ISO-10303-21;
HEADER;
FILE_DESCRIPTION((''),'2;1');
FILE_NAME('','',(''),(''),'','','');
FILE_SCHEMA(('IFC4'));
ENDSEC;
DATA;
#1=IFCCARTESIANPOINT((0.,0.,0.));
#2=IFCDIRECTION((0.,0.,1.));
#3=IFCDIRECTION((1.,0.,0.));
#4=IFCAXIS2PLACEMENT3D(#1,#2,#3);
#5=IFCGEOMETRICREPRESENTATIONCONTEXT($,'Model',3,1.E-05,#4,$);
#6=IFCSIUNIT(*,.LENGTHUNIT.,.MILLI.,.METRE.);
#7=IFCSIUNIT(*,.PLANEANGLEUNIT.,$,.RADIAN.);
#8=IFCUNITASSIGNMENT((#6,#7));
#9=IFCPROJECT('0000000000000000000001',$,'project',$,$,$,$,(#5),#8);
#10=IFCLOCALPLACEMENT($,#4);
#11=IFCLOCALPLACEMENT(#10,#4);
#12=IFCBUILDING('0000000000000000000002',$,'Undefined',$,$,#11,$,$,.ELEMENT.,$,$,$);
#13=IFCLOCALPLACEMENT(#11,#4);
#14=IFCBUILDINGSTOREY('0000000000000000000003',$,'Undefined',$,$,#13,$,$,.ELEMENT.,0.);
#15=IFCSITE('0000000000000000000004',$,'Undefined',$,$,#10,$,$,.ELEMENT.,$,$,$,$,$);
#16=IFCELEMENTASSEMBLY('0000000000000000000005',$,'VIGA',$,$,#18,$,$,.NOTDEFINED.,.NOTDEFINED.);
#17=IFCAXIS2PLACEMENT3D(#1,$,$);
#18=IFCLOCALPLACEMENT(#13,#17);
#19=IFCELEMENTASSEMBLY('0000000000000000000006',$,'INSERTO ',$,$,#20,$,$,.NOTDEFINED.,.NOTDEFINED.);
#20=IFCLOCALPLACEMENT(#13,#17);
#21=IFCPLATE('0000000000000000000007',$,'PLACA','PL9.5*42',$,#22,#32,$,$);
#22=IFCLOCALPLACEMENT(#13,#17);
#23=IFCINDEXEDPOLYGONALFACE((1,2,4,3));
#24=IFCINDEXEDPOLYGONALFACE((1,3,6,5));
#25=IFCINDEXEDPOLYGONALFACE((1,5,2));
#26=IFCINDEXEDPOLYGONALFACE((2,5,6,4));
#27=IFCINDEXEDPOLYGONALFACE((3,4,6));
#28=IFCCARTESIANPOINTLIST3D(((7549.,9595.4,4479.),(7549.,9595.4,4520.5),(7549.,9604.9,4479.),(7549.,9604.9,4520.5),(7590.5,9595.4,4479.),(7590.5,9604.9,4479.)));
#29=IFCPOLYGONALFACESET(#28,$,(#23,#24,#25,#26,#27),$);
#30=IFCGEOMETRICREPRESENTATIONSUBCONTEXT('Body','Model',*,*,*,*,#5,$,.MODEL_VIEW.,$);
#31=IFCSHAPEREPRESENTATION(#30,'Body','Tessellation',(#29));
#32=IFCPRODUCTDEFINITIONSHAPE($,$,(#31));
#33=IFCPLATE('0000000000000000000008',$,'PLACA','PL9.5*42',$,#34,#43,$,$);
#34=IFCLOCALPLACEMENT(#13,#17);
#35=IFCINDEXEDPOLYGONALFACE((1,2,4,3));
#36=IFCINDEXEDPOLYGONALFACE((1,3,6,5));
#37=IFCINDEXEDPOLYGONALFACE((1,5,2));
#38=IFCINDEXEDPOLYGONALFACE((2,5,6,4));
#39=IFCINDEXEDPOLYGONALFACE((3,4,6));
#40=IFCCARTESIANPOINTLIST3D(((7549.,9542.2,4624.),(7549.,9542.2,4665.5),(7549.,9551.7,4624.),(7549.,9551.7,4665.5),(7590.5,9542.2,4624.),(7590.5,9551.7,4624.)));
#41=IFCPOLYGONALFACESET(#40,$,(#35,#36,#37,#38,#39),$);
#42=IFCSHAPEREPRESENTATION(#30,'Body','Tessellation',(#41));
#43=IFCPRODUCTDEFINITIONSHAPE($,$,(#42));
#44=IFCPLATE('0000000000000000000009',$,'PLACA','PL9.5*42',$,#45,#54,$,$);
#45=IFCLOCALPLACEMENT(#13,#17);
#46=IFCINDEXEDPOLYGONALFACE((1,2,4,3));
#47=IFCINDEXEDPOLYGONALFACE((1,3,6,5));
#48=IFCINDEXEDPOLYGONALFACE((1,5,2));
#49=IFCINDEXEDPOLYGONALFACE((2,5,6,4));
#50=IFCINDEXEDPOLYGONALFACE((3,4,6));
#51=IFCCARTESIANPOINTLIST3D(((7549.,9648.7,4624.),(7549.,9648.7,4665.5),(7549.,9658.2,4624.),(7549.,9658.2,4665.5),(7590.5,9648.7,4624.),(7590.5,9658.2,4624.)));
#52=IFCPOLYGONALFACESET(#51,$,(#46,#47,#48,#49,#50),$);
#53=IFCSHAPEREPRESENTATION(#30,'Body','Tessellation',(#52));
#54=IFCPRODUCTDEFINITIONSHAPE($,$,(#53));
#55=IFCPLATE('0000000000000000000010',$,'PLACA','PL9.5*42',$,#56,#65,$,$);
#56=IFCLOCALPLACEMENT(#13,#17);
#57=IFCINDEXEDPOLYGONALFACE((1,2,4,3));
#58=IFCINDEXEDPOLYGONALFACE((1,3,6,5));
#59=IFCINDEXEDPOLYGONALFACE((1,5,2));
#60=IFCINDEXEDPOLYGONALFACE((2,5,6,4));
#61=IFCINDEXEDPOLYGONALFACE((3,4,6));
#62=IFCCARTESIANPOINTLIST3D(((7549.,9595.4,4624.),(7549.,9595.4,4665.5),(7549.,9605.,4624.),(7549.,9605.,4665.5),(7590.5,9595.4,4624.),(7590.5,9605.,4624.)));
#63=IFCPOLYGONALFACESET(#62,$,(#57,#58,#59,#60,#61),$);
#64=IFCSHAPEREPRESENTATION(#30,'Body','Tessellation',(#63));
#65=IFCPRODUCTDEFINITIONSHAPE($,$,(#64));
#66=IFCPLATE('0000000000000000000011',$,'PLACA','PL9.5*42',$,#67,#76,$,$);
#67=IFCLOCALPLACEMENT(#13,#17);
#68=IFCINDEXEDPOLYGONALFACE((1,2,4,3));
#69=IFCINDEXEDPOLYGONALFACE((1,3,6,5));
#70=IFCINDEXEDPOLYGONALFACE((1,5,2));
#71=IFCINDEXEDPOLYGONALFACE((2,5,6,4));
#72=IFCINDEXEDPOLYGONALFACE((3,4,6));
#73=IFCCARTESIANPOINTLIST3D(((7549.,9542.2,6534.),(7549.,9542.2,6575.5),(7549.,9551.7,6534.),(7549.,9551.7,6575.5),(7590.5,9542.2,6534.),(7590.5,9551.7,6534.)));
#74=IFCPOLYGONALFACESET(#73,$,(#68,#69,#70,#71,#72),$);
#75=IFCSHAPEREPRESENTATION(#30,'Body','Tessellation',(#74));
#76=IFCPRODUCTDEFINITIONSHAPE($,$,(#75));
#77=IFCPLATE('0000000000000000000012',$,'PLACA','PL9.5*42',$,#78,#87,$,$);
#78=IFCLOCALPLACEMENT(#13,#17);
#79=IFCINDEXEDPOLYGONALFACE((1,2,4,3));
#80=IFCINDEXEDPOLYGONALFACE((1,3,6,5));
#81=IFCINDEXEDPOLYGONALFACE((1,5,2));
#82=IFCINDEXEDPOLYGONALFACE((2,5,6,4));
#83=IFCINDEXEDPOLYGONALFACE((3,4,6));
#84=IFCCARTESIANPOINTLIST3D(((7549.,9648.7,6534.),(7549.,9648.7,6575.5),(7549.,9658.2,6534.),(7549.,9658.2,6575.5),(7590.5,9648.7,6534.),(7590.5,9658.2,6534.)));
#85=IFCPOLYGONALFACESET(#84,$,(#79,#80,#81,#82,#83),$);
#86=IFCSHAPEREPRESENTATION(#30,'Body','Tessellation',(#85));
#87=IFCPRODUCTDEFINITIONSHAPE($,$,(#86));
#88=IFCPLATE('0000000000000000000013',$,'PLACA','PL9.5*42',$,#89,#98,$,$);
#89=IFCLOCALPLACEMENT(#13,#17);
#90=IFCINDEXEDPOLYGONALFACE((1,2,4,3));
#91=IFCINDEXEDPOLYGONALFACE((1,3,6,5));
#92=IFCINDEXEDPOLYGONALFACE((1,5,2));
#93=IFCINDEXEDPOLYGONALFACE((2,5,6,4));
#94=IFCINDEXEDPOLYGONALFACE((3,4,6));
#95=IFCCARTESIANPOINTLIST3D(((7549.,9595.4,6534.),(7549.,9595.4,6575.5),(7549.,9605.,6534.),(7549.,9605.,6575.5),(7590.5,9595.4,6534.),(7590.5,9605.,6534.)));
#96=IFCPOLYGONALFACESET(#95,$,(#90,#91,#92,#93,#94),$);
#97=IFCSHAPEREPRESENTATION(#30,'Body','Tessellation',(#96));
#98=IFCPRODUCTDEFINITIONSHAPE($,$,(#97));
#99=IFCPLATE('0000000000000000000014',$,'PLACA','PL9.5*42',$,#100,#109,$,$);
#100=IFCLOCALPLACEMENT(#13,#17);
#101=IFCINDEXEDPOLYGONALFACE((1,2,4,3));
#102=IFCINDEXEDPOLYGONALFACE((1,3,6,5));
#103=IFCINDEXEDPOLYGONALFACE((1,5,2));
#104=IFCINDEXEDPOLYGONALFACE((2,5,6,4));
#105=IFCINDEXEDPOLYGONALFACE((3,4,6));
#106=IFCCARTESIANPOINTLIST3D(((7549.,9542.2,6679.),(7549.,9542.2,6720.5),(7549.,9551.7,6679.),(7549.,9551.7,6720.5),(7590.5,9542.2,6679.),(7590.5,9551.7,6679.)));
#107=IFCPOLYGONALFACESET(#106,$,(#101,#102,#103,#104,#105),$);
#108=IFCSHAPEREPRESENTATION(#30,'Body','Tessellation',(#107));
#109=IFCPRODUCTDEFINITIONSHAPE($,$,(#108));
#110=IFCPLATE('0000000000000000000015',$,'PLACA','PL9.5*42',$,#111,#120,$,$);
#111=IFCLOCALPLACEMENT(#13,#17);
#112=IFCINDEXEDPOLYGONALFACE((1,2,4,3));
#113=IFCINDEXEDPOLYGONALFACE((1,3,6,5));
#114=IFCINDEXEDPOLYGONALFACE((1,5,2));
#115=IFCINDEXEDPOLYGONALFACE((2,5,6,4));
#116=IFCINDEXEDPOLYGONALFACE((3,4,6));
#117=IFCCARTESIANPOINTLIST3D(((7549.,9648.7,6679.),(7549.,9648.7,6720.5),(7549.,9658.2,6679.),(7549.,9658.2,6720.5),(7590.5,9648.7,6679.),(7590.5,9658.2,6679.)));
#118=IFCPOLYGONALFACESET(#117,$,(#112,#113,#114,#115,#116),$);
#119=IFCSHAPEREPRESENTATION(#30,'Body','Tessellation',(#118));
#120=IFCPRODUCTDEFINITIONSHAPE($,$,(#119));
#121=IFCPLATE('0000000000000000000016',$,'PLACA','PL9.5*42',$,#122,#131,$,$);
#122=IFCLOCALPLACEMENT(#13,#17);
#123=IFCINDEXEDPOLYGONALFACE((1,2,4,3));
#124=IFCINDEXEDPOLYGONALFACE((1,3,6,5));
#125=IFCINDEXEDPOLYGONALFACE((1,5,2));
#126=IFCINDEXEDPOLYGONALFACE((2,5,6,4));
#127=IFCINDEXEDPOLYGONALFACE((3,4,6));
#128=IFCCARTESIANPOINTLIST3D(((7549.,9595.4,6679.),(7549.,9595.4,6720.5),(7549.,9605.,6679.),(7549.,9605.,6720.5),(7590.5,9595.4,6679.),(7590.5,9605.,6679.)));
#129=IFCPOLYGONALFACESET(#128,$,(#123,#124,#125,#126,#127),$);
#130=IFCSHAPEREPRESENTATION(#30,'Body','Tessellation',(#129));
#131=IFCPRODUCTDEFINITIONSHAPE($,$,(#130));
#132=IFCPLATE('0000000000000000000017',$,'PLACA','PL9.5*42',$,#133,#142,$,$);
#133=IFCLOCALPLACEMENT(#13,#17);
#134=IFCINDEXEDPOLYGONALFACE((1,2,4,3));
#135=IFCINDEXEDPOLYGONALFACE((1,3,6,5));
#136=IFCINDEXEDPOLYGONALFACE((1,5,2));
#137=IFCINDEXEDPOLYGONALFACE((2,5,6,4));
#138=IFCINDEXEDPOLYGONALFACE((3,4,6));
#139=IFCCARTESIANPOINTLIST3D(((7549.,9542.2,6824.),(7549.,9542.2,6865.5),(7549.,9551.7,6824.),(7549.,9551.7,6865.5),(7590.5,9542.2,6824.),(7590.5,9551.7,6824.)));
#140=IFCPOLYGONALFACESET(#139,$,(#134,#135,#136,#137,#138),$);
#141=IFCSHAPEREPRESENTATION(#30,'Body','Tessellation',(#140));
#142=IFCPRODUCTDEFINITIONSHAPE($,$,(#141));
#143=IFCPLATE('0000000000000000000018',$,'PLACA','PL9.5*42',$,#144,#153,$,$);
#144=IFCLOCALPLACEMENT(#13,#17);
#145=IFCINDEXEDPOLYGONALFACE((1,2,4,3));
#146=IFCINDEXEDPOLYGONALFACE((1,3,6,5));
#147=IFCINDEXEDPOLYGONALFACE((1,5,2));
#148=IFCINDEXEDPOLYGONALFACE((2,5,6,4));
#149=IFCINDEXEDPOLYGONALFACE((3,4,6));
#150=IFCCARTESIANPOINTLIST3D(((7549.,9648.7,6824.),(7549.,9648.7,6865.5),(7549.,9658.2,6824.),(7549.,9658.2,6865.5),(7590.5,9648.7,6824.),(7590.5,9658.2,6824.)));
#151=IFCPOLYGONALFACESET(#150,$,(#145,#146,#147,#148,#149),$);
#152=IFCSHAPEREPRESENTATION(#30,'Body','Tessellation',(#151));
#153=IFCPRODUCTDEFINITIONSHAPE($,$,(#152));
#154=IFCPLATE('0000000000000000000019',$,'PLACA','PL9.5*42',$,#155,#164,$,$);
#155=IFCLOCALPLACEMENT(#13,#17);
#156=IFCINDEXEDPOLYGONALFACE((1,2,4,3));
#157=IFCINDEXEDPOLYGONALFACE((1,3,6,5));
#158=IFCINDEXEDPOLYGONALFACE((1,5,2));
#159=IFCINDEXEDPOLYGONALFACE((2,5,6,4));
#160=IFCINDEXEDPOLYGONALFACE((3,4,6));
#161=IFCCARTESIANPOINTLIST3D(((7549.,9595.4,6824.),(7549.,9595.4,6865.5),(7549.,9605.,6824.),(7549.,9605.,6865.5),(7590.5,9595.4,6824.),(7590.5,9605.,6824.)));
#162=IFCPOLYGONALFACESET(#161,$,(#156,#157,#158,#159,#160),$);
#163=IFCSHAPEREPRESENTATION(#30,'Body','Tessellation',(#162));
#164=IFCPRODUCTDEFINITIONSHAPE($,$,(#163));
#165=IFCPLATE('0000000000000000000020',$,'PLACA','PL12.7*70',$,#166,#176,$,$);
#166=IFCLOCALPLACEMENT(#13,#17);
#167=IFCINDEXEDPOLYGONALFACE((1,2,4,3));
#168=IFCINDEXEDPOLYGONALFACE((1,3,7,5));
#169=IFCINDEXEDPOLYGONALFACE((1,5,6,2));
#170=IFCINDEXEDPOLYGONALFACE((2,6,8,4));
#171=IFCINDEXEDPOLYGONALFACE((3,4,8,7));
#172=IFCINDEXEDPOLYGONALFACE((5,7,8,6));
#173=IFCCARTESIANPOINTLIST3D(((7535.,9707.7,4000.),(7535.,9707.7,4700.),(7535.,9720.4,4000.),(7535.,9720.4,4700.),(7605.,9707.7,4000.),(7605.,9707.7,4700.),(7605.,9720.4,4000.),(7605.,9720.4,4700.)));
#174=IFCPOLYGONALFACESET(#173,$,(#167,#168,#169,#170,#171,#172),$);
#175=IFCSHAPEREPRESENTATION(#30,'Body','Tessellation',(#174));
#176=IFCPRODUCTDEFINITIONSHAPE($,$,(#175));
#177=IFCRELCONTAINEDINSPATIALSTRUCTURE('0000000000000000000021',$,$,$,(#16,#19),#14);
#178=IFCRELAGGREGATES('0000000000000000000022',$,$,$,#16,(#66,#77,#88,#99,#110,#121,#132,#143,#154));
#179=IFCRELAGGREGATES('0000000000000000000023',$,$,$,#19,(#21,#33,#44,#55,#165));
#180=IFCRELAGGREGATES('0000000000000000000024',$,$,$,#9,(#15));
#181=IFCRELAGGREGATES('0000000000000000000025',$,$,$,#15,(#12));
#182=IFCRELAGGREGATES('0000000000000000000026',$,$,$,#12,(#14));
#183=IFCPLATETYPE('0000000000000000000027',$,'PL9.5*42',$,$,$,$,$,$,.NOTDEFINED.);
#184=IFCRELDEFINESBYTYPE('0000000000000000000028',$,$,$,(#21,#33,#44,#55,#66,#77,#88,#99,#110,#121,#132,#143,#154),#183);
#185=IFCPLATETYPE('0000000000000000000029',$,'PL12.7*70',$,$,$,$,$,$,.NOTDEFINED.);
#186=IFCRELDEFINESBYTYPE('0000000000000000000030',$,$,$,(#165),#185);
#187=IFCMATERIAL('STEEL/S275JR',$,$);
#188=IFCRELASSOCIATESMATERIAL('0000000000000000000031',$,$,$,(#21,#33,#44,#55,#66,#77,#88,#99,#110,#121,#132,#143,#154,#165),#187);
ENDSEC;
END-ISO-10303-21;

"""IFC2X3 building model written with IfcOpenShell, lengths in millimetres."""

from ifc_helpers import new_model, si_unit, frame, origin_with_axes, place, context, subcontext, project, spatial, polyline, outline, extrude, material, type_object, element, aggregate, save


model = new_model("IFC2X3")

# Units and contexts
model_context = context("Model", 3, precision=1e-05, world=origin_with_axes())
body_context = subcontext(model_context, "Body", "Model", "MODEL_VIEW")
ifc_project = project(units=[si_unit("LENGTHUNIT", "METRE", prefix="MILLI"), si_unit("PLANEANGLEUNIT", "RADIAN")], contexts=[model_context])

# Site, building, storey
site_placement = place(None, origin_with_axes())
site = spatial("IfcSite", under=ifc_project, at=site_placement, Name="Undefined", CompositionType="ELEMENT")
building_placement = place(site_placement, origin_with_axes())
building = spatial("IfcBuilding", under=site, at=building_placement, Name="Undefined", CompositionType="ELEMENT")
storey_placement = place(building_placement, origin_with_axes())
storey = spatial("IfcBuildingStorey", under=building, at=storey_placement, Name="Undefined", CompositionType="ELEMENT", Elevation=0.0)

# Element assembly
assembly_1_placement = place(storey_placement, origin_with_axes())
assembly_1 = element("IfcElementAssembly", 1, at=assembly_1_placement, inside=storey, Name="VIGA", AssemblyPlace="NOTDEFINED", PredefinedType="NOTDEFINED")
ifc_material = material(Name="STEEL/S275JR")

# Element assembly, plates
assembly_2_placement = place(storey_placement, origin_with_axes())
assembly_2 = element("IfcElementAssembly", 2, at=assembly_2_placement, inside=storey, Name="INSERTO ", AssemblyPlace="NOTDEFINED", PredefinedType="NOTDEFINED")
plate_type_1 = type_object("IfcPlateType", Name="PL9.5*42", PredefinedType="NOTDEFINED")
plate_1_placement = place(assembly_2_placement, frame((7549.0, 9600.2, 4479.0), z_axis=(0.0, 1.0, 0.0), x_axis=(0.0, 0.0, 1.0)))
plate_1 = element("IfcPlate", 3, at=plate_1_placement, type_object=plate_type_1, material=ifc_material, Name="PLACA", Description="PL9.5*42", context=body_context, shape_type="SweptSolid", body=[
    extrude(outline(polyline([(0.0, 0.0), (41.5, 0.0), (0.0, 41.5), (0.0, 0.0)])), frame((0.0, 0.0, -4.7), z_axis=(0.0, 0.0, 1.0), x_axis=(1.0, 0.0, 0.0)), (0.0, 0.0, 1.0), 9.5),
])
plate_2_placement = place(assembly_2_placement, frame((7549.0, 9547.0, 4624.0), z_axis=(0.0, 1.0, 0.0), x_axis=(0.0, 0.0, 1.0)))
plate_2 = element("IfcPlate", 4, at=plate_2_placement, type_object=plate_type_1, material=ifc_material, Name="PLACA", Description="PL9.5*42", context=body_context, shape_type="SweptSolid", body=[
    extrude(outline(polyline([(0.0, 0.0), (41.5, 0.0), (0.0, 41.5), (0.0, 0.0)])), frame((0.0, 0.0, -4.7), z_axis=(0.0, 0.0, 1.0), x_axis=(1.0, 0.0, 0.0)), (0.0, 0.0, 1.0), 9.5),
])
plate_3_placement = place(assembly_2_placement, frame((7549.0, 9653.5, 4624.0), z_axis=(0.0, 1.0, 0.0), x_axis=(0.0, 0.0, 1.0)))
plate_3 = element("IfcPlate", 5, at=plate_3_placement, type_object=plate_type_1, material=ifc_material, Name="PLACA", Description="PL9.5*42", context=body_context, shape_type="SweptSolid", body=[
    extrude(outline(polyline([(0.0, 0.0), (41.5, 0.0), (0.0, 41.5), (0.0, 0.0)])), frame((0.0, 0.0, -4.7), z_axis=(0.0, 0.0, 1.0), x_axis=(1.0, 0.0, 0.0)), (0.0, 0.0, 1.0), 9.5),
])
plate_4_placement = place(assembly_2_placement, frame((7549.0, 9600.2, 4624.0), z_axis=(0.0, 1.0, 0.0), x_axis=(0.0, 0.0, 1.0)))
plate_4 = element("IfcPlate", 6, at=plate_4_placement, type_object=plate_type_1, material=ifc_material, Name="PLACA", Description="PL9.5*42", context=body_context, shape_type="SweptSolid", body=[
    extrude(outline(polyline([(0.0, 0.0), (41.5, 0.0), (0.0, 41.5), (0.0, 0.0)])), frame((0.0, 0.0, -4.7), z_axis=(0.0, 0.0, 1.0), x_axis=(1.0, 0.0, 0.0)), (0.0, 0.0, 1.0), 9.5),
])

# Plates
plate_5_placement = place(assembly_1_placement, frame((7549.0, 9547.0, 6534.0), z_axis=(0.0, 1.0, 0.0), x_axis=(0.0, 0.0, 1.0)))
plate_5 = element("IfcPlate", 7, at=plate_5_placement, type_object=plate_type_1, material=ifc_material, Name="PLACA", Description="PL9.5*42", context=body_context, shape_type="SweptSolid", body=[
    extrude(outline(polyline([(0.0, 0.0), (41.5, 0.0), (0.0, 41.5), (0.0, 0.0)])), frame((0.0, 0.0, -4.7), z_axis=(0.0, 0.0, 1.0), x_axis=(1.0, 0.0, 0.0)), (0.0, 0.0, 1.0), 9.5),
])
plate_6_placement = place(assembly_1_placement, frame((7549.0, 9653.5, 6534.0), z_axis=(0.0, 1.0, 0.0), x_axis=(0.0, 0.0, 1.0)))
plate_6 = element("IfcPlate", 8, at=plate_6_placement, type_object=plate_type_1, material=ifc_material, Name="PLACA", Description="PL9.5*42", context=body_context, shape_type="SweptSolid", body=[
    extrude(outline(polyline([(0.0, 0.0), (41.5, 0.0), (0.0, 41.5), (0.0, 0.0)])), frame((0.0, 0.0, -4.7), z_axis=(0.0, 0.0, 1.0), x_axis=(1.0, 0.0, 0.0)), (0.0, 0.0, 1.0), 9.5),
])
plate_7_placement = place(assembly_1_placement, frame((7549.0, 9600.2, 6534.0), z_axis=(0.0, 1.0, 0.0), x_axis=(0.0, 0.0, 1.0)))
plate_7 = element("IfcPlate", 9, at=plate_7_placement, type_object=plate_type_1, material=ifc_material, Name="PLACA", Description="PL9.5*42", context=body_context, shape_type="SweptSolid", body=[
    extrude(outline(polyline([(0.0, 0.0), (41.5, 0.0), (0.0, 41.5), (0.0, 0.0)])), frame((0.0, 0.0, -4.7), z_axis=(0.0, 0.0, 1.0), x_axis=(1.0, 0.0, 0.0)), (0.0, 0.0, 1.0), 9.5),
])
plate_8_placement = place(assembly_1_placement, frame((7549.0, 9547.0, 6679.0), z_axis=(0.0, 1.0, 0.0), x_axis=(0.0, 0.0, 1.0)))
plate_8 = element("IfcPlate", 10, at=plate_8_placement, type_object=plate_type_1, material=ifc_material, Name="PLACA", Description="PL9.5*42", context=body_context, shape_type="SweptSolid", body=[
    extrude(outline(polyline([(0.0, 0.0), (41.5, 0.0), (0.0, 41.5), (0.0, 0.0)])), frame((0.0, 0.0, -4.7), z_axis=(0.0, 0.0, 1.0), x_axis=(1.0, 0.0, 0.0)), (0.0, 0.0, 1.0), 9.5),
])
plate_9_placement = place(assembly_1_placement, frame((7549.0, 9653.5, 6679.0), z_axis=(0.0, 1.0, 0.0), x_axis=(0.0, 0.0, 1.0)))
plate_9 = element("IfcPlate", 11, at=plate_9_placement, type_object=plate_type_1, material=ifc_material, Name="PLACA", Description="PL9.5*42", context=body_context, shape_type="SweptSolid", body=[
    extrude(outline(polyline([(0.0, 0.0), (41.5, 0.0), (0.0, 41.5), (0.0, 0.0)])), frame((0.0, 0.0, -4.7), z_axis=(0.0, 0.0, 1.0), x_axis=(1.0, 0.0, 0.0)), (0.0, 0.0, 1.0), 9.5),
])
plate_10_placement = place(assembly_1_placement, frame((7549.0, 9600.2, 6679.0), z_axis=(0.0, 1.0, 0.0), x_axis=(0.0, 0.0, 1.0)))
plate_10 = element("IfcPlate", 12, at=plate_10_placement, type_object=plate_type_1, material=ifc_material, Name="PLACA", Description="PL9.5*42", context=body_context, shape_type="SweptSolid", body=[
    extrude(outline(polyline([(0.0, 0.0), (41.5, 0.0), (0.0, 41.5), (0.0, 0.0)])), frame((0.0, 0.0, -4.7), z_axis=(0.0, 0.0, 1.0), x_axis=(1.0, 0.0, 0.0)), (0.0, 0.0, 1.0), 9.5),
])
plate_11_placement = place(assembly_1_placement, frame((7549.0, 9547.0, 6824.0), z_axis=(0.0, 1.0, 0.0), x_axis=(0.0, 0.0, 1.0)))
plate_11 = element("IfcPlate", 13, at=plate_11_placement, type_object=plate_type_1, material=ifc_material, Name="PLACA", Description="PL9.5*42", context=body_context, shape_type="SweptSolid", body=[
    extrude(outline(polyline([(0.0, 0.0), (41.5, 0.0), (0.0, 41.5), (0.0, 0.0)])), frame((0.0, 0.0, -4.7), z_axis=(0.0, 0.0, 1.0), x_axis=(1.0, 0.0, 0.0)), (0.0, 0.0, 1.0), 9.5),
])
plate_12_placement = place(assembly_1_placement, frame((7549.0, 9653.5, 6824.0), z_axis=(0.0, 1.0, 0.0), x_axis=(0.0, 0.0, 1.0)))
plate_12 = element("IfcPlate", 14, at=plate_12_placement, type_object=plate_type_1, material=ifc_material, Name="PLACA", Description="PL9.5*42", context=body_context, shape_type="SweptSolid", body=[
    extrude(outline(polyline([(0.0, 0.0), (41.5, 0.0), (0.0, 41.5), (0.0, 0.0)])), frame((0.0, 0.0, -4.7), z_axis=(0.0, 0.0, 1.0), x_axis=(1.0, 0.0, 0.0)), (0.0, 0.0, 1.0), 9.5),
])
plate_13_placement = place(assembly_1_placement, frame((7549.0, 9600.2, 6824.0), z_axis=(0.0, 1.0, 0.0), x_axis=(0.0, 0.0, 1.0)))
plate_13 = element("IfcPlate", 15, at=plate_13_placement, type_object=plate_type_1, material=ifc_material, Name="PLACA", Description="PL9.5*42", context=body_context, shape_type="SweptSolid", body=[
    extrude(outline(polyline([(0.0, 0.0), (41.5, 0.0), (0.0, 41.5), (0.0, 0.0)])), frame((0.0, 0.0, -4.7), z_axis=(0.0, 0.0, 1.0), x_axis=(1.0, 0.0, 0.0)), (0.0, 0.0, 1.0), 9.5),
])
aggregate(assembly_1, [plate_5, plate_6, plate_7, plate_8, plate_9, plate_10, plate_11, plate_12, plate_13])
plate_type_2 = type_object("IfcPlateType", Name="PL12.7*70", PredefinedType="NOTDEFINED")
plate_14_placement = place(assembly_2_placement, frame((7535.0, 9714.0, 4700.0), z_axis=(0.0, 1.0, 0.0), x_axis=(1.0, 0.0, 0.0)))
plate_14 = element("IfcPlate", 16, at=plate_14_placement, type_object=plate_type_2, material=ifc_material, Name="PLACA", Description="PL12.7*70", context=body_context, shape_type="SweptSolid", body=[
    extrude(outline(polyline([(0.0, 0.0), (70.0, 0.0), (70.0, 700.0), (0.0, 700.0), (0.0, 0.0)])), frame((0.0, 0.0, -6.3), z_axis=(0.0, 0.0, 1.0), x_axis=(1.0, 0.0, 0.0)), (0.0, 0.0, 1.0), 12.7),
])
aggregate(assembly_2, [plate_1, plate_2, plate_3, plate_4, plate_14])

save(model, "model.ifc")
